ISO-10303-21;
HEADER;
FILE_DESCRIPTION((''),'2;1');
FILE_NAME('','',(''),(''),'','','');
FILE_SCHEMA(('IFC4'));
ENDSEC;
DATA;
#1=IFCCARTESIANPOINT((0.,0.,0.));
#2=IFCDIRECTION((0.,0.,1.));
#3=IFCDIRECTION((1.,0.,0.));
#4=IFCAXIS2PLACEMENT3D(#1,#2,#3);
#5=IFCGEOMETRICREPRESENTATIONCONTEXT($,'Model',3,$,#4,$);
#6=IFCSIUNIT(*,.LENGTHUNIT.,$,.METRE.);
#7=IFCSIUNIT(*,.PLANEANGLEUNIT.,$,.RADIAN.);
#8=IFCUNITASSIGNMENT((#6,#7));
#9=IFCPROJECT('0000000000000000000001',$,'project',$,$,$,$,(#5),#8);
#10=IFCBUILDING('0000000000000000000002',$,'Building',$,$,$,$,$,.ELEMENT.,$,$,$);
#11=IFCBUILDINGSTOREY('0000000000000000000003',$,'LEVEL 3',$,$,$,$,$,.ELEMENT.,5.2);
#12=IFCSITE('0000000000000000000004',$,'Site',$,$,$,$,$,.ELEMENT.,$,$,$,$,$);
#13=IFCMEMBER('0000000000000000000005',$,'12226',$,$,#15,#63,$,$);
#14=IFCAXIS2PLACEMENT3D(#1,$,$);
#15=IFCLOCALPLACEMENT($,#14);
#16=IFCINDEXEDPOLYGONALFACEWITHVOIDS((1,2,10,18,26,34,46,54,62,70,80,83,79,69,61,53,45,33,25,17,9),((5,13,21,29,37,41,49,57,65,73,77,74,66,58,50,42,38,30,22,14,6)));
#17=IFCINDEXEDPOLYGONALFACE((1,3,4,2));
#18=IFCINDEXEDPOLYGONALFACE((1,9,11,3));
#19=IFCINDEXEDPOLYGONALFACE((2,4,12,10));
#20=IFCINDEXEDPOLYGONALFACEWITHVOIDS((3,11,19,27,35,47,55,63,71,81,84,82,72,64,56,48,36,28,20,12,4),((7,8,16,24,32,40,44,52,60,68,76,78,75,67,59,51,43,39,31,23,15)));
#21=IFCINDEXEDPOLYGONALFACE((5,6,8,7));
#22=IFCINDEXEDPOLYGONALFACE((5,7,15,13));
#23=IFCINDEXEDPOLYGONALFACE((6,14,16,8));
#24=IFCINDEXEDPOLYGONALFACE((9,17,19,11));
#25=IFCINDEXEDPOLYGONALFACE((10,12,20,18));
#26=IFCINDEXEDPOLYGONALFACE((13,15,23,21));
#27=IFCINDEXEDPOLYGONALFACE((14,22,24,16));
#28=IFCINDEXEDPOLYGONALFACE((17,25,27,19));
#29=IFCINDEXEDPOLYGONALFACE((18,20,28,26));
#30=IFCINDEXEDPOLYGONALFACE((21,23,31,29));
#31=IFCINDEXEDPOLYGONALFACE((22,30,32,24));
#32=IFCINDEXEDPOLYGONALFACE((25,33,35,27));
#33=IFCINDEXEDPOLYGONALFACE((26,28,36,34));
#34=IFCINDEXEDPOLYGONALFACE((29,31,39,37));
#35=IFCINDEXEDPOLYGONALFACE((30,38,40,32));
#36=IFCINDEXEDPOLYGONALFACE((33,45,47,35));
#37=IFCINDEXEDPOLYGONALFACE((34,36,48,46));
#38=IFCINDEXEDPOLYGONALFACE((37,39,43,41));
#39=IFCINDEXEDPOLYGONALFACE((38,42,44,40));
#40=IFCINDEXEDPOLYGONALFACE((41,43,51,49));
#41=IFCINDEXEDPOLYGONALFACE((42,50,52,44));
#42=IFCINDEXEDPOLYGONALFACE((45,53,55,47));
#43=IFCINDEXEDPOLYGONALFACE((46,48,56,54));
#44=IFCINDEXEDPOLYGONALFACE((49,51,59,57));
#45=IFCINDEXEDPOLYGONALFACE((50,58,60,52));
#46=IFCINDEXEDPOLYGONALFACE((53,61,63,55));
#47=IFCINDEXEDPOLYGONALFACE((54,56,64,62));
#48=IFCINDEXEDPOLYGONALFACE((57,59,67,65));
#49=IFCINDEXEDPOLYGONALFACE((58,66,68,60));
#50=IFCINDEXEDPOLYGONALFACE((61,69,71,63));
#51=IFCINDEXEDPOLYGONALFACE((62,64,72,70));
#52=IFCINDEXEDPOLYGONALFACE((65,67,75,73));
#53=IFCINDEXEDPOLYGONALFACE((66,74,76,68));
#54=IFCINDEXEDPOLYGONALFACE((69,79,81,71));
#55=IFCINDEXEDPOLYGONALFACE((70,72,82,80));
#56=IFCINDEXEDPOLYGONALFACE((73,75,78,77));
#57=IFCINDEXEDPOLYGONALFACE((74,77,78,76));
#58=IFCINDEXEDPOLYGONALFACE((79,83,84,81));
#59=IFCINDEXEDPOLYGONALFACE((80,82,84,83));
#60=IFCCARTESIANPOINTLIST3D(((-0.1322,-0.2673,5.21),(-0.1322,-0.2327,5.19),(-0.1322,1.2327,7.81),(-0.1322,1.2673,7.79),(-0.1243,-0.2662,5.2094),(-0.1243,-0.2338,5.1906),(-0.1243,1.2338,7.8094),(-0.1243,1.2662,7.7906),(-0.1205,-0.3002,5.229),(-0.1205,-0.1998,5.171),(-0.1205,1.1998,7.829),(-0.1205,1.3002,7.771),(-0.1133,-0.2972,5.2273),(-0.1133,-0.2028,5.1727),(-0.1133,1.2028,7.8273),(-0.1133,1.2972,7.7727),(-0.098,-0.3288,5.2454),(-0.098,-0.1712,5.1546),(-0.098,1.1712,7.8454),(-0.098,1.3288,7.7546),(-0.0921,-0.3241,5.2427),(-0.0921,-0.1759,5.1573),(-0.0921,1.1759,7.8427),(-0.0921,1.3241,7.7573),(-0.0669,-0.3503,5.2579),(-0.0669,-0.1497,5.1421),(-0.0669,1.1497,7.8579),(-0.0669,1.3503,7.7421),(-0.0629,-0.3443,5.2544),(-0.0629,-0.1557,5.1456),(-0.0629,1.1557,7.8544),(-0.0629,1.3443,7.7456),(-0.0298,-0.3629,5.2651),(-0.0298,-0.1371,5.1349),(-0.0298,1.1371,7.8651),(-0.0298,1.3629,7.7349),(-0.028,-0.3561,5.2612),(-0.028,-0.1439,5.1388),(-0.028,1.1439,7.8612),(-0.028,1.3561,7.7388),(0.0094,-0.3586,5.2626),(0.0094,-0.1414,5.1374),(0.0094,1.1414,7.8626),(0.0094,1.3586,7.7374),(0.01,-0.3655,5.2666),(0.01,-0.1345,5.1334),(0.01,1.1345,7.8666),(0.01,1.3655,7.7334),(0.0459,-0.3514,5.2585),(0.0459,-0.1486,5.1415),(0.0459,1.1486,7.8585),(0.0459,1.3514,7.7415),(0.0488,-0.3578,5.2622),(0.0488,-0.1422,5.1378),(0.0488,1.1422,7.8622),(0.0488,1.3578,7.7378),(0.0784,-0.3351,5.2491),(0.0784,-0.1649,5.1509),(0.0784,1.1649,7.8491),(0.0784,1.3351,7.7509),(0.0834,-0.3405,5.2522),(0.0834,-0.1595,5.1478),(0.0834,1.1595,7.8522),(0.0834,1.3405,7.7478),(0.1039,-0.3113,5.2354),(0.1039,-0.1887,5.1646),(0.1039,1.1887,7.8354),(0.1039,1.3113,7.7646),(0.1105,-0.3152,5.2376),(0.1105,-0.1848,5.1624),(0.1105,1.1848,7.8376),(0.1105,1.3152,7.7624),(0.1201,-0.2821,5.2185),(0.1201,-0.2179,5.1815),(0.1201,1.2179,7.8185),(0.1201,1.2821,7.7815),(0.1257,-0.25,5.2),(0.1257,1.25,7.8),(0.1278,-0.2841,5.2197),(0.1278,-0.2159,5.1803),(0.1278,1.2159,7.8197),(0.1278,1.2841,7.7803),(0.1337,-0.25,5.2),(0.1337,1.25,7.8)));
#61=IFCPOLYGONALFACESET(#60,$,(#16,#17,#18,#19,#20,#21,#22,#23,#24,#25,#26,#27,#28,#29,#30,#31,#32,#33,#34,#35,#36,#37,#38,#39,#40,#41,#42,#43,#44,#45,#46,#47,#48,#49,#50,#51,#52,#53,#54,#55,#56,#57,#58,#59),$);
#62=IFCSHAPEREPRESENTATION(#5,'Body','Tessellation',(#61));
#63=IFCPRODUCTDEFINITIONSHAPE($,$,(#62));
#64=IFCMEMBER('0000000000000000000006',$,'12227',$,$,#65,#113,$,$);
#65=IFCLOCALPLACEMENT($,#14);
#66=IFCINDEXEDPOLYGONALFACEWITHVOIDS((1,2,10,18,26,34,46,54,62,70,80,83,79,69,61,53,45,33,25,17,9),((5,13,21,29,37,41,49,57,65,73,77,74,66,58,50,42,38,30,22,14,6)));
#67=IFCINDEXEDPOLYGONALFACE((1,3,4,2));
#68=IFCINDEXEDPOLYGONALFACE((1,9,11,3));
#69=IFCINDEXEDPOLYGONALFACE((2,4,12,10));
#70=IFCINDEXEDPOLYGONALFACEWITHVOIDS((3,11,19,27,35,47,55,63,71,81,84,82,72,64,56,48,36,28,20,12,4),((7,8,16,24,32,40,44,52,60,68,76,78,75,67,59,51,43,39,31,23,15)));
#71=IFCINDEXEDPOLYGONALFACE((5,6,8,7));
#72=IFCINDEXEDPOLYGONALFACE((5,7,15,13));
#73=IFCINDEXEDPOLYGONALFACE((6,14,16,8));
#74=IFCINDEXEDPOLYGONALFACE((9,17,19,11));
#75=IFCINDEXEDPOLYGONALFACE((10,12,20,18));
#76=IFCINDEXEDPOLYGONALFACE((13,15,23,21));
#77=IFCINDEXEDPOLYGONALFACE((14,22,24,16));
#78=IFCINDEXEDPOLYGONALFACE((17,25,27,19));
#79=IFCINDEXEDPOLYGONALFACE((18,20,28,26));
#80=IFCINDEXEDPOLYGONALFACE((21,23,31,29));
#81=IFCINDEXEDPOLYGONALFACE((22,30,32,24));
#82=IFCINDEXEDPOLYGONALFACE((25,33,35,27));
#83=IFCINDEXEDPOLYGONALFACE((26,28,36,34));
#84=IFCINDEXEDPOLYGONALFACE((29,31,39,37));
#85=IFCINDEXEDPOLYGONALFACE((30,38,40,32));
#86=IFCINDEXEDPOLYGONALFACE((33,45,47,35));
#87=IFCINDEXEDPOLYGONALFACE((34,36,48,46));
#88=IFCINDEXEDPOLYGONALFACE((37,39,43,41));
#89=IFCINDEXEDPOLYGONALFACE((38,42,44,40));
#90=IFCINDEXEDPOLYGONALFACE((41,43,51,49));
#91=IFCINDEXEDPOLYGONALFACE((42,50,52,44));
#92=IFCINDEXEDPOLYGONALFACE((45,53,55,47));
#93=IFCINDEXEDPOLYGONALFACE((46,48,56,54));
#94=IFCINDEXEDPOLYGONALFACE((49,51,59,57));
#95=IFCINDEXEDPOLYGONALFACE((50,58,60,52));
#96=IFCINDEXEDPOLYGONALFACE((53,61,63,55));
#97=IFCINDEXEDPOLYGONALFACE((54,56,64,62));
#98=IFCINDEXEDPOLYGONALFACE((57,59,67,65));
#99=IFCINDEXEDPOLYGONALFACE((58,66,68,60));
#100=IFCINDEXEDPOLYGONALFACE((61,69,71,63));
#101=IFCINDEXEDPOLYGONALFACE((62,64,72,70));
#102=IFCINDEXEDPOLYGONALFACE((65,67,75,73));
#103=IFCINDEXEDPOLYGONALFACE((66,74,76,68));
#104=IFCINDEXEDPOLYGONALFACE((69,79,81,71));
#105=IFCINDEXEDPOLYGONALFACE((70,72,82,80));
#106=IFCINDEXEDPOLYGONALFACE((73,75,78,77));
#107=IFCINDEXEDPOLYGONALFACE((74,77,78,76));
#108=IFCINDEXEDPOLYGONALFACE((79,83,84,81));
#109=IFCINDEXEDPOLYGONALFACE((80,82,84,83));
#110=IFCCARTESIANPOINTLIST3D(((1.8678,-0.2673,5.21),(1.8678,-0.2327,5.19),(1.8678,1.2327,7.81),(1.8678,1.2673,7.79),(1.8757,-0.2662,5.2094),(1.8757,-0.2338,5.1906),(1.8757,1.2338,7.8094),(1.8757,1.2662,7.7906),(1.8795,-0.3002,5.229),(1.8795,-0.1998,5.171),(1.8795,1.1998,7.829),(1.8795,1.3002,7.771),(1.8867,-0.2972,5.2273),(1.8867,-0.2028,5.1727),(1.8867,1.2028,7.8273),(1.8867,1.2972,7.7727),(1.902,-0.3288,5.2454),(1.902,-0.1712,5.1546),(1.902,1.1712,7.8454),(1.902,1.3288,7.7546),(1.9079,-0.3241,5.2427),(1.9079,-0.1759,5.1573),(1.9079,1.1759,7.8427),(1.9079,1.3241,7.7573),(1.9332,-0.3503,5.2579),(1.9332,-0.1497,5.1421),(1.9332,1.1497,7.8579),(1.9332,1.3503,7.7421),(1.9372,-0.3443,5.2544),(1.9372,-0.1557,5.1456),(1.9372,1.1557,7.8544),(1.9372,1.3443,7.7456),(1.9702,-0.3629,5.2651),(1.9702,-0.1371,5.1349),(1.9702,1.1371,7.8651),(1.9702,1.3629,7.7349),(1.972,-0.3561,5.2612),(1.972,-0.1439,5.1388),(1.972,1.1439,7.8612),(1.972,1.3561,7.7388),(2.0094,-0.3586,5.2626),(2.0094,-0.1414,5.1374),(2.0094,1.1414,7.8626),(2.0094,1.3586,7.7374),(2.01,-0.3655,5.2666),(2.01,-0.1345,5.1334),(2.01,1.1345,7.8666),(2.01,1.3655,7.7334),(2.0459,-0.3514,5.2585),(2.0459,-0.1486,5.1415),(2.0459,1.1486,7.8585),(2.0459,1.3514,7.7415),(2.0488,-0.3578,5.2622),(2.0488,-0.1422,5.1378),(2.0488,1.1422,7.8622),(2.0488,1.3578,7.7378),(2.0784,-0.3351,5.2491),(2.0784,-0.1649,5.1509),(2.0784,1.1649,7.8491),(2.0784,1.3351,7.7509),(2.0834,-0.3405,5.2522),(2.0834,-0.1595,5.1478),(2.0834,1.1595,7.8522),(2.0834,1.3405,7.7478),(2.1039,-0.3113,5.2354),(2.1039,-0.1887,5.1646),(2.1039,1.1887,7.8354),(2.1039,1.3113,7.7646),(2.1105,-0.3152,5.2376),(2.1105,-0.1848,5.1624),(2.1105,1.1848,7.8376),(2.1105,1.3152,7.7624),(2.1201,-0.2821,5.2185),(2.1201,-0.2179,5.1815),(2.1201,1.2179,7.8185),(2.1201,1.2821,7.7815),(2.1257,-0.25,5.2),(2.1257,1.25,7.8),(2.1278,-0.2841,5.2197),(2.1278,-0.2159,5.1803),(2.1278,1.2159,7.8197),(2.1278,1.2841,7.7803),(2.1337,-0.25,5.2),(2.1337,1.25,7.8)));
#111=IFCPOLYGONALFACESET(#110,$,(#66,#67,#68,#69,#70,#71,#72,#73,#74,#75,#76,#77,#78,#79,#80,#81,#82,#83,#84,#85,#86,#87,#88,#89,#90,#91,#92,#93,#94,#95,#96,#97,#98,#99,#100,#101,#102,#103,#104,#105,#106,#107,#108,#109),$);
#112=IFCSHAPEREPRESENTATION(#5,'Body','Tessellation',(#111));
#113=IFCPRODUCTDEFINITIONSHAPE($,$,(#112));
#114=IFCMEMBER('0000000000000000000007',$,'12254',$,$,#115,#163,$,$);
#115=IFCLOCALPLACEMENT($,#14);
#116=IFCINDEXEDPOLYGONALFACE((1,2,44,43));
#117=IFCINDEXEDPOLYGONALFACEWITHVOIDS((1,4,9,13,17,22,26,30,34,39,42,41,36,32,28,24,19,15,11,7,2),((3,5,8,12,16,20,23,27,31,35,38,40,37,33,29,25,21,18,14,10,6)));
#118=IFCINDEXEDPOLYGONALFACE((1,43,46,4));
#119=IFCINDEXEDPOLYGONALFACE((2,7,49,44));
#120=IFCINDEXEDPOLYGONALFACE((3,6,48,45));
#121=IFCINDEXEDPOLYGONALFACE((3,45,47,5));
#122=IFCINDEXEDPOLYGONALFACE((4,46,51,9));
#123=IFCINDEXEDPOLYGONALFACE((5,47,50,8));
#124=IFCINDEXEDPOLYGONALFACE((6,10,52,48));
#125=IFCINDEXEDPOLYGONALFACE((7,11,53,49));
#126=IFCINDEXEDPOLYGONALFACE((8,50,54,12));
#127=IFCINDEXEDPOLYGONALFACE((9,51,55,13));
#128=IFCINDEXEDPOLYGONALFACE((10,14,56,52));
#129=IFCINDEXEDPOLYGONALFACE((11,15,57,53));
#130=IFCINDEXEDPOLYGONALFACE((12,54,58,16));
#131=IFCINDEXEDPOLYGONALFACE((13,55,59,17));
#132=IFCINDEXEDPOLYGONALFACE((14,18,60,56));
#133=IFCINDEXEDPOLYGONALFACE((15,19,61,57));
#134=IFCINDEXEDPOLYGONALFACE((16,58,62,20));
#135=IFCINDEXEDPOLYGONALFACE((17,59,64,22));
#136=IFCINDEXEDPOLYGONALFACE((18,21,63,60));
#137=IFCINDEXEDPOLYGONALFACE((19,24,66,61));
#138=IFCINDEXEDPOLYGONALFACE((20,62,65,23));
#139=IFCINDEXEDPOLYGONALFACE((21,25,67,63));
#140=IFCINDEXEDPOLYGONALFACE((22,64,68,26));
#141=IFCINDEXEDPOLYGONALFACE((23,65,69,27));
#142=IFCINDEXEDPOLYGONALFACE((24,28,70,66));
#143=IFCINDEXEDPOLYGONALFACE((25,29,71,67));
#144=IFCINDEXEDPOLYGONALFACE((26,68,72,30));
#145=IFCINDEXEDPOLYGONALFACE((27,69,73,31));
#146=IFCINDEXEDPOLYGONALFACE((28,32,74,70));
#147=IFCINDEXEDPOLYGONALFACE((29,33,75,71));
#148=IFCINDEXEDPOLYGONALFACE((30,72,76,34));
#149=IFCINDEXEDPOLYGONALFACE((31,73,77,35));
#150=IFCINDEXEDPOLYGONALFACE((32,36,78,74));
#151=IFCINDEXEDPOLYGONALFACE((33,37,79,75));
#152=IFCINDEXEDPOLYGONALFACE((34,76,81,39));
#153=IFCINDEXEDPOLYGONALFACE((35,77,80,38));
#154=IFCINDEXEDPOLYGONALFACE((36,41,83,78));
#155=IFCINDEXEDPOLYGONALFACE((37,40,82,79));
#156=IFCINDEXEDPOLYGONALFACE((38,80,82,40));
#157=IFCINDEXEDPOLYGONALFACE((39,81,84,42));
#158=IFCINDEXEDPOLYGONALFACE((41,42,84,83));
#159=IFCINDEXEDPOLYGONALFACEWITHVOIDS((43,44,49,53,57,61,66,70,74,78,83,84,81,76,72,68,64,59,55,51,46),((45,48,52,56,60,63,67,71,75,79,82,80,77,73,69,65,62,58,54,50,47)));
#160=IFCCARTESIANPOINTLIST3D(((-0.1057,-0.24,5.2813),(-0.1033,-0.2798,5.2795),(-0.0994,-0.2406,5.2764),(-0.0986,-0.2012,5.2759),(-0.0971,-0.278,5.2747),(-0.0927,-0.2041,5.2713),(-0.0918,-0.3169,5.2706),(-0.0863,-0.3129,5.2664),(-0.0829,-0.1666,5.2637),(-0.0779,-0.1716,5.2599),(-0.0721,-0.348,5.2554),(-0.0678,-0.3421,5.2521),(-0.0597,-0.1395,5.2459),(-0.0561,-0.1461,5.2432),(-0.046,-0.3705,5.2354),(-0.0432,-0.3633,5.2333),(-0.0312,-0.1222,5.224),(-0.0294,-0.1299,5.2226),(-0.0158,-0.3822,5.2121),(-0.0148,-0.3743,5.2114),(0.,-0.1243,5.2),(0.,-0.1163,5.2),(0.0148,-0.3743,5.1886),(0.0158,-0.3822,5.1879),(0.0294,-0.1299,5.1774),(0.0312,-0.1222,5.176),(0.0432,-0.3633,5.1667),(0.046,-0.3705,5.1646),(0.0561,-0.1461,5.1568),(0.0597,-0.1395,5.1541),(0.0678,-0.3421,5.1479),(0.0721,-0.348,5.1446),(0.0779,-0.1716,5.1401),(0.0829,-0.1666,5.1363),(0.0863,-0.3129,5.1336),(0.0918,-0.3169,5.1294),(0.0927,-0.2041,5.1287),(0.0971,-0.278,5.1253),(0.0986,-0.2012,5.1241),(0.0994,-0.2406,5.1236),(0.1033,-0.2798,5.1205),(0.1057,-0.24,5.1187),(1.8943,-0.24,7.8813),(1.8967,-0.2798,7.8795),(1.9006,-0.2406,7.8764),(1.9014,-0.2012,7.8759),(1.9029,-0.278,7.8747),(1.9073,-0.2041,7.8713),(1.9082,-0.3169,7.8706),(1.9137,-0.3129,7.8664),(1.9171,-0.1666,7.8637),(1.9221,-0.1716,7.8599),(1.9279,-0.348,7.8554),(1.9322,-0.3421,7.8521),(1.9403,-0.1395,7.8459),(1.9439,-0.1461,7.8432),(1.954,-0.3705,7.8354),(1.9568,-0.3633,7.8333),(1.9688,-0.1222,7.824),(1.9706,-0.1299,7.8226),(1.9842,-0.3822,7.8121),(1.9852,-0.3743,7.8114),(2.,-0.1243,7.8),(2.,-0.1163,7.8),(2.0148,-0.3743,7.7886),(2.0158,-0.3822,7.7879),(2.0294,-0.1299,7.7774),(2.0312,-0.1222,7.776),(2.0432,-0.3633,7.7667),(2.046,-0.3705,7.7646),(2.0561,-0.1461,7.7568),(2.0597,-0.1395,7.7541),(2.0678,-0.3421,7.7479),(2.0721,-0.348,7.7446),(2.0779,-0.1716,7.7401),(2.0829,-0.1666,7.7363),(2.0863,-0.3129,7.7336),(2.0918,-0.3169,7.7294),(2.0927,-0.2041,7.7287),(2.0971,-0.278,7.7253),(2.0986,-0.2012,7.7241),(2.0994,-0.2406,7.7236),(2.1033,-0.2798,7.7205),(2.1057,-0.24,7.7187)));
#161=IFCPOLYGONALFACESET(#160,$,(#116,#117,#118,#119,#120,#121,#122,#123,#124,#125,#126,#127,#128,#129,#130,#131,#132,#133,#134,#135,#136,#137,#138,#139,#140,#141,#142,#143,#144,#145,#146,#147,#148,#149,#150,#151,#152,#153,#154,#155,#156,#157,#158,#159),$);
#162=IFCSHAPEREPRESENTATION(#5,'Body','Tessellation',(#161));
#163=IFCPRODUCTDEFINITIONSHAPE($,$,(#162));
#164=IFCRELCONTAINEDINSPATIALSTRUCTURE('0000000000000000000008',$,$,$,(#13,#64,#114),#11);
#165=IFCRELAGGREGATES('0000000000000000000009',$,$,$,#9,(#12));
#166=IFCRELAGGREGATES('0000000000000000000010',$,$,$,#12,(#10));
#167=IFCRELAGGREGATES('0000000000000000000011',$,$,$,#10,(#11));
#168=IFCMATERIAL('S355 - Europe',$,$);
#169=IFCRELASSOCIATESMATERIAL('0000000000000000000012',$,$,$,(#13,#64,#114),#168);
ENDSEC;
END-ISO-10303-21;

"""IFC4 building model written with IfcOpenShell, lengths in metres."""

from ifc_helpers import new_model, si_unit, frame, origin_with_axes, origin_2d_with_axis, place, context, project, spatial, hollow_circle, extrude, material, material_profile, profile_set, profile_usage, element, save


model = new_model("IFC4")

# Units and contexts
model_context = context("Model", 3, world=origin_with_axes())
ifc_project = project(units=[si_unit("LENGTHUNIT", "METRE"), si_unit("PLANEANGLEUNIT", "RADIAN")], contexts=[model_context])

# Site, building, storey
site = spatial("IfcSite", under=ifc_project, Name="Site", CompositionType="ELEMENT")
building = spatial("IfcBuilding", under=site, Name="Building", CompositionType="ELEMENT")
storey = spatial("IfcBuildingStorey", under=building, Name="LEVEL 3", CompositionType="ELEMENT", Elevation=5.2)

# Shared definitions
ifc_material = material(Name="S355 - Europe")

# Members
ifc_material_profile_1 = material_profile(ifc_material, hollow_circle(Radius=0.1337, WallThickness=0.008, at=origin_2d_with_axis()))
ifc_profile_set_1 = profile_set([ifc_material_profile_1])
ifc_profile_usage_1 = profile_usage(ifc_profile_set_1, cardinal=10)
member_1_placement = place(None, frame((0.0, 1.25, 7.8), z_axis=(0.0, -0.499722, -0.866186), x_axis=(1.0, 0.0, 0.0)))
element("IfcMember", 1, at=member_1_placement, inside=storey, material=ifc_profile_usage_1, Name="12226", context=model_context, shape_type="SweptSolid", body=[
    extrude(hollow_circle(Radius=0.1337, WallThickness=0.008, at=origin_2d_with_axis()), origin_with_axes(), (0.0, 0.0, 1.0), 3.0017),
])
ifc_material_profile_2 = material_profile(ifc_material, hollow_circle(Radius=0.1337, WallThickness=0.008, at=origin_2d_with_axis()))
ifc_profile_set_2 = profile_set([ifc_material_profile_2])
ifc_profile_usage_2 = profile_usage(ifc_profile_set_2, cardinal=10)
member_2_placement = place(None, frame((2.0, 1.25, 7.8), z_axis=(0.0, -0.499722, -0.866186), x_axis=(1.0, 0.0, 0.0)))
element("IfcMember", 2, at=member_2_placement, inside=storey, material=ifc_profile_usage_2, Name="12227", context=model_context, shape_type="SweptSolid", body=[
    extrude(hollow_circle(Radius=0.1337, WallThickness=0.008, at=origin_2d_with_axis()), origin_with_axes(), (0.0, 0.0, 1.0), 3.0017),
])
ifc_material_profile_3 = material_profile(ifc_material, hollow_circle(Radius=0.1337, WallThickness=0.008, at=origin_2d_with_axis()))
ifc_profile_set_3 = profile_set([ifc_material_profile_3])
ifc_profile_usage_3 = profile_usage(ifc_profile_set_3, cardinal=10)
member_3_placement = place(None, frame((0.0, -0.25, 5.2), z_axis=(0.609711, 0.0, 0.792624), x_axis=(0.0, 1.0, 0.0)))
element("IfcMember", 3, at=member_3_placement, inside=storey, material=ifc_profile_usage_3, Name="12254", context=model_context, shape_type="SweptSolid", body=[
    extrude(hollow_circle(Radius=0.1337, WallThickness=0.008, at=origin_2d_with_axis()), origin_with_axes(), (0.0, 0.0, 1.0), 3.2802),
])

save(model, "model.ifc")
